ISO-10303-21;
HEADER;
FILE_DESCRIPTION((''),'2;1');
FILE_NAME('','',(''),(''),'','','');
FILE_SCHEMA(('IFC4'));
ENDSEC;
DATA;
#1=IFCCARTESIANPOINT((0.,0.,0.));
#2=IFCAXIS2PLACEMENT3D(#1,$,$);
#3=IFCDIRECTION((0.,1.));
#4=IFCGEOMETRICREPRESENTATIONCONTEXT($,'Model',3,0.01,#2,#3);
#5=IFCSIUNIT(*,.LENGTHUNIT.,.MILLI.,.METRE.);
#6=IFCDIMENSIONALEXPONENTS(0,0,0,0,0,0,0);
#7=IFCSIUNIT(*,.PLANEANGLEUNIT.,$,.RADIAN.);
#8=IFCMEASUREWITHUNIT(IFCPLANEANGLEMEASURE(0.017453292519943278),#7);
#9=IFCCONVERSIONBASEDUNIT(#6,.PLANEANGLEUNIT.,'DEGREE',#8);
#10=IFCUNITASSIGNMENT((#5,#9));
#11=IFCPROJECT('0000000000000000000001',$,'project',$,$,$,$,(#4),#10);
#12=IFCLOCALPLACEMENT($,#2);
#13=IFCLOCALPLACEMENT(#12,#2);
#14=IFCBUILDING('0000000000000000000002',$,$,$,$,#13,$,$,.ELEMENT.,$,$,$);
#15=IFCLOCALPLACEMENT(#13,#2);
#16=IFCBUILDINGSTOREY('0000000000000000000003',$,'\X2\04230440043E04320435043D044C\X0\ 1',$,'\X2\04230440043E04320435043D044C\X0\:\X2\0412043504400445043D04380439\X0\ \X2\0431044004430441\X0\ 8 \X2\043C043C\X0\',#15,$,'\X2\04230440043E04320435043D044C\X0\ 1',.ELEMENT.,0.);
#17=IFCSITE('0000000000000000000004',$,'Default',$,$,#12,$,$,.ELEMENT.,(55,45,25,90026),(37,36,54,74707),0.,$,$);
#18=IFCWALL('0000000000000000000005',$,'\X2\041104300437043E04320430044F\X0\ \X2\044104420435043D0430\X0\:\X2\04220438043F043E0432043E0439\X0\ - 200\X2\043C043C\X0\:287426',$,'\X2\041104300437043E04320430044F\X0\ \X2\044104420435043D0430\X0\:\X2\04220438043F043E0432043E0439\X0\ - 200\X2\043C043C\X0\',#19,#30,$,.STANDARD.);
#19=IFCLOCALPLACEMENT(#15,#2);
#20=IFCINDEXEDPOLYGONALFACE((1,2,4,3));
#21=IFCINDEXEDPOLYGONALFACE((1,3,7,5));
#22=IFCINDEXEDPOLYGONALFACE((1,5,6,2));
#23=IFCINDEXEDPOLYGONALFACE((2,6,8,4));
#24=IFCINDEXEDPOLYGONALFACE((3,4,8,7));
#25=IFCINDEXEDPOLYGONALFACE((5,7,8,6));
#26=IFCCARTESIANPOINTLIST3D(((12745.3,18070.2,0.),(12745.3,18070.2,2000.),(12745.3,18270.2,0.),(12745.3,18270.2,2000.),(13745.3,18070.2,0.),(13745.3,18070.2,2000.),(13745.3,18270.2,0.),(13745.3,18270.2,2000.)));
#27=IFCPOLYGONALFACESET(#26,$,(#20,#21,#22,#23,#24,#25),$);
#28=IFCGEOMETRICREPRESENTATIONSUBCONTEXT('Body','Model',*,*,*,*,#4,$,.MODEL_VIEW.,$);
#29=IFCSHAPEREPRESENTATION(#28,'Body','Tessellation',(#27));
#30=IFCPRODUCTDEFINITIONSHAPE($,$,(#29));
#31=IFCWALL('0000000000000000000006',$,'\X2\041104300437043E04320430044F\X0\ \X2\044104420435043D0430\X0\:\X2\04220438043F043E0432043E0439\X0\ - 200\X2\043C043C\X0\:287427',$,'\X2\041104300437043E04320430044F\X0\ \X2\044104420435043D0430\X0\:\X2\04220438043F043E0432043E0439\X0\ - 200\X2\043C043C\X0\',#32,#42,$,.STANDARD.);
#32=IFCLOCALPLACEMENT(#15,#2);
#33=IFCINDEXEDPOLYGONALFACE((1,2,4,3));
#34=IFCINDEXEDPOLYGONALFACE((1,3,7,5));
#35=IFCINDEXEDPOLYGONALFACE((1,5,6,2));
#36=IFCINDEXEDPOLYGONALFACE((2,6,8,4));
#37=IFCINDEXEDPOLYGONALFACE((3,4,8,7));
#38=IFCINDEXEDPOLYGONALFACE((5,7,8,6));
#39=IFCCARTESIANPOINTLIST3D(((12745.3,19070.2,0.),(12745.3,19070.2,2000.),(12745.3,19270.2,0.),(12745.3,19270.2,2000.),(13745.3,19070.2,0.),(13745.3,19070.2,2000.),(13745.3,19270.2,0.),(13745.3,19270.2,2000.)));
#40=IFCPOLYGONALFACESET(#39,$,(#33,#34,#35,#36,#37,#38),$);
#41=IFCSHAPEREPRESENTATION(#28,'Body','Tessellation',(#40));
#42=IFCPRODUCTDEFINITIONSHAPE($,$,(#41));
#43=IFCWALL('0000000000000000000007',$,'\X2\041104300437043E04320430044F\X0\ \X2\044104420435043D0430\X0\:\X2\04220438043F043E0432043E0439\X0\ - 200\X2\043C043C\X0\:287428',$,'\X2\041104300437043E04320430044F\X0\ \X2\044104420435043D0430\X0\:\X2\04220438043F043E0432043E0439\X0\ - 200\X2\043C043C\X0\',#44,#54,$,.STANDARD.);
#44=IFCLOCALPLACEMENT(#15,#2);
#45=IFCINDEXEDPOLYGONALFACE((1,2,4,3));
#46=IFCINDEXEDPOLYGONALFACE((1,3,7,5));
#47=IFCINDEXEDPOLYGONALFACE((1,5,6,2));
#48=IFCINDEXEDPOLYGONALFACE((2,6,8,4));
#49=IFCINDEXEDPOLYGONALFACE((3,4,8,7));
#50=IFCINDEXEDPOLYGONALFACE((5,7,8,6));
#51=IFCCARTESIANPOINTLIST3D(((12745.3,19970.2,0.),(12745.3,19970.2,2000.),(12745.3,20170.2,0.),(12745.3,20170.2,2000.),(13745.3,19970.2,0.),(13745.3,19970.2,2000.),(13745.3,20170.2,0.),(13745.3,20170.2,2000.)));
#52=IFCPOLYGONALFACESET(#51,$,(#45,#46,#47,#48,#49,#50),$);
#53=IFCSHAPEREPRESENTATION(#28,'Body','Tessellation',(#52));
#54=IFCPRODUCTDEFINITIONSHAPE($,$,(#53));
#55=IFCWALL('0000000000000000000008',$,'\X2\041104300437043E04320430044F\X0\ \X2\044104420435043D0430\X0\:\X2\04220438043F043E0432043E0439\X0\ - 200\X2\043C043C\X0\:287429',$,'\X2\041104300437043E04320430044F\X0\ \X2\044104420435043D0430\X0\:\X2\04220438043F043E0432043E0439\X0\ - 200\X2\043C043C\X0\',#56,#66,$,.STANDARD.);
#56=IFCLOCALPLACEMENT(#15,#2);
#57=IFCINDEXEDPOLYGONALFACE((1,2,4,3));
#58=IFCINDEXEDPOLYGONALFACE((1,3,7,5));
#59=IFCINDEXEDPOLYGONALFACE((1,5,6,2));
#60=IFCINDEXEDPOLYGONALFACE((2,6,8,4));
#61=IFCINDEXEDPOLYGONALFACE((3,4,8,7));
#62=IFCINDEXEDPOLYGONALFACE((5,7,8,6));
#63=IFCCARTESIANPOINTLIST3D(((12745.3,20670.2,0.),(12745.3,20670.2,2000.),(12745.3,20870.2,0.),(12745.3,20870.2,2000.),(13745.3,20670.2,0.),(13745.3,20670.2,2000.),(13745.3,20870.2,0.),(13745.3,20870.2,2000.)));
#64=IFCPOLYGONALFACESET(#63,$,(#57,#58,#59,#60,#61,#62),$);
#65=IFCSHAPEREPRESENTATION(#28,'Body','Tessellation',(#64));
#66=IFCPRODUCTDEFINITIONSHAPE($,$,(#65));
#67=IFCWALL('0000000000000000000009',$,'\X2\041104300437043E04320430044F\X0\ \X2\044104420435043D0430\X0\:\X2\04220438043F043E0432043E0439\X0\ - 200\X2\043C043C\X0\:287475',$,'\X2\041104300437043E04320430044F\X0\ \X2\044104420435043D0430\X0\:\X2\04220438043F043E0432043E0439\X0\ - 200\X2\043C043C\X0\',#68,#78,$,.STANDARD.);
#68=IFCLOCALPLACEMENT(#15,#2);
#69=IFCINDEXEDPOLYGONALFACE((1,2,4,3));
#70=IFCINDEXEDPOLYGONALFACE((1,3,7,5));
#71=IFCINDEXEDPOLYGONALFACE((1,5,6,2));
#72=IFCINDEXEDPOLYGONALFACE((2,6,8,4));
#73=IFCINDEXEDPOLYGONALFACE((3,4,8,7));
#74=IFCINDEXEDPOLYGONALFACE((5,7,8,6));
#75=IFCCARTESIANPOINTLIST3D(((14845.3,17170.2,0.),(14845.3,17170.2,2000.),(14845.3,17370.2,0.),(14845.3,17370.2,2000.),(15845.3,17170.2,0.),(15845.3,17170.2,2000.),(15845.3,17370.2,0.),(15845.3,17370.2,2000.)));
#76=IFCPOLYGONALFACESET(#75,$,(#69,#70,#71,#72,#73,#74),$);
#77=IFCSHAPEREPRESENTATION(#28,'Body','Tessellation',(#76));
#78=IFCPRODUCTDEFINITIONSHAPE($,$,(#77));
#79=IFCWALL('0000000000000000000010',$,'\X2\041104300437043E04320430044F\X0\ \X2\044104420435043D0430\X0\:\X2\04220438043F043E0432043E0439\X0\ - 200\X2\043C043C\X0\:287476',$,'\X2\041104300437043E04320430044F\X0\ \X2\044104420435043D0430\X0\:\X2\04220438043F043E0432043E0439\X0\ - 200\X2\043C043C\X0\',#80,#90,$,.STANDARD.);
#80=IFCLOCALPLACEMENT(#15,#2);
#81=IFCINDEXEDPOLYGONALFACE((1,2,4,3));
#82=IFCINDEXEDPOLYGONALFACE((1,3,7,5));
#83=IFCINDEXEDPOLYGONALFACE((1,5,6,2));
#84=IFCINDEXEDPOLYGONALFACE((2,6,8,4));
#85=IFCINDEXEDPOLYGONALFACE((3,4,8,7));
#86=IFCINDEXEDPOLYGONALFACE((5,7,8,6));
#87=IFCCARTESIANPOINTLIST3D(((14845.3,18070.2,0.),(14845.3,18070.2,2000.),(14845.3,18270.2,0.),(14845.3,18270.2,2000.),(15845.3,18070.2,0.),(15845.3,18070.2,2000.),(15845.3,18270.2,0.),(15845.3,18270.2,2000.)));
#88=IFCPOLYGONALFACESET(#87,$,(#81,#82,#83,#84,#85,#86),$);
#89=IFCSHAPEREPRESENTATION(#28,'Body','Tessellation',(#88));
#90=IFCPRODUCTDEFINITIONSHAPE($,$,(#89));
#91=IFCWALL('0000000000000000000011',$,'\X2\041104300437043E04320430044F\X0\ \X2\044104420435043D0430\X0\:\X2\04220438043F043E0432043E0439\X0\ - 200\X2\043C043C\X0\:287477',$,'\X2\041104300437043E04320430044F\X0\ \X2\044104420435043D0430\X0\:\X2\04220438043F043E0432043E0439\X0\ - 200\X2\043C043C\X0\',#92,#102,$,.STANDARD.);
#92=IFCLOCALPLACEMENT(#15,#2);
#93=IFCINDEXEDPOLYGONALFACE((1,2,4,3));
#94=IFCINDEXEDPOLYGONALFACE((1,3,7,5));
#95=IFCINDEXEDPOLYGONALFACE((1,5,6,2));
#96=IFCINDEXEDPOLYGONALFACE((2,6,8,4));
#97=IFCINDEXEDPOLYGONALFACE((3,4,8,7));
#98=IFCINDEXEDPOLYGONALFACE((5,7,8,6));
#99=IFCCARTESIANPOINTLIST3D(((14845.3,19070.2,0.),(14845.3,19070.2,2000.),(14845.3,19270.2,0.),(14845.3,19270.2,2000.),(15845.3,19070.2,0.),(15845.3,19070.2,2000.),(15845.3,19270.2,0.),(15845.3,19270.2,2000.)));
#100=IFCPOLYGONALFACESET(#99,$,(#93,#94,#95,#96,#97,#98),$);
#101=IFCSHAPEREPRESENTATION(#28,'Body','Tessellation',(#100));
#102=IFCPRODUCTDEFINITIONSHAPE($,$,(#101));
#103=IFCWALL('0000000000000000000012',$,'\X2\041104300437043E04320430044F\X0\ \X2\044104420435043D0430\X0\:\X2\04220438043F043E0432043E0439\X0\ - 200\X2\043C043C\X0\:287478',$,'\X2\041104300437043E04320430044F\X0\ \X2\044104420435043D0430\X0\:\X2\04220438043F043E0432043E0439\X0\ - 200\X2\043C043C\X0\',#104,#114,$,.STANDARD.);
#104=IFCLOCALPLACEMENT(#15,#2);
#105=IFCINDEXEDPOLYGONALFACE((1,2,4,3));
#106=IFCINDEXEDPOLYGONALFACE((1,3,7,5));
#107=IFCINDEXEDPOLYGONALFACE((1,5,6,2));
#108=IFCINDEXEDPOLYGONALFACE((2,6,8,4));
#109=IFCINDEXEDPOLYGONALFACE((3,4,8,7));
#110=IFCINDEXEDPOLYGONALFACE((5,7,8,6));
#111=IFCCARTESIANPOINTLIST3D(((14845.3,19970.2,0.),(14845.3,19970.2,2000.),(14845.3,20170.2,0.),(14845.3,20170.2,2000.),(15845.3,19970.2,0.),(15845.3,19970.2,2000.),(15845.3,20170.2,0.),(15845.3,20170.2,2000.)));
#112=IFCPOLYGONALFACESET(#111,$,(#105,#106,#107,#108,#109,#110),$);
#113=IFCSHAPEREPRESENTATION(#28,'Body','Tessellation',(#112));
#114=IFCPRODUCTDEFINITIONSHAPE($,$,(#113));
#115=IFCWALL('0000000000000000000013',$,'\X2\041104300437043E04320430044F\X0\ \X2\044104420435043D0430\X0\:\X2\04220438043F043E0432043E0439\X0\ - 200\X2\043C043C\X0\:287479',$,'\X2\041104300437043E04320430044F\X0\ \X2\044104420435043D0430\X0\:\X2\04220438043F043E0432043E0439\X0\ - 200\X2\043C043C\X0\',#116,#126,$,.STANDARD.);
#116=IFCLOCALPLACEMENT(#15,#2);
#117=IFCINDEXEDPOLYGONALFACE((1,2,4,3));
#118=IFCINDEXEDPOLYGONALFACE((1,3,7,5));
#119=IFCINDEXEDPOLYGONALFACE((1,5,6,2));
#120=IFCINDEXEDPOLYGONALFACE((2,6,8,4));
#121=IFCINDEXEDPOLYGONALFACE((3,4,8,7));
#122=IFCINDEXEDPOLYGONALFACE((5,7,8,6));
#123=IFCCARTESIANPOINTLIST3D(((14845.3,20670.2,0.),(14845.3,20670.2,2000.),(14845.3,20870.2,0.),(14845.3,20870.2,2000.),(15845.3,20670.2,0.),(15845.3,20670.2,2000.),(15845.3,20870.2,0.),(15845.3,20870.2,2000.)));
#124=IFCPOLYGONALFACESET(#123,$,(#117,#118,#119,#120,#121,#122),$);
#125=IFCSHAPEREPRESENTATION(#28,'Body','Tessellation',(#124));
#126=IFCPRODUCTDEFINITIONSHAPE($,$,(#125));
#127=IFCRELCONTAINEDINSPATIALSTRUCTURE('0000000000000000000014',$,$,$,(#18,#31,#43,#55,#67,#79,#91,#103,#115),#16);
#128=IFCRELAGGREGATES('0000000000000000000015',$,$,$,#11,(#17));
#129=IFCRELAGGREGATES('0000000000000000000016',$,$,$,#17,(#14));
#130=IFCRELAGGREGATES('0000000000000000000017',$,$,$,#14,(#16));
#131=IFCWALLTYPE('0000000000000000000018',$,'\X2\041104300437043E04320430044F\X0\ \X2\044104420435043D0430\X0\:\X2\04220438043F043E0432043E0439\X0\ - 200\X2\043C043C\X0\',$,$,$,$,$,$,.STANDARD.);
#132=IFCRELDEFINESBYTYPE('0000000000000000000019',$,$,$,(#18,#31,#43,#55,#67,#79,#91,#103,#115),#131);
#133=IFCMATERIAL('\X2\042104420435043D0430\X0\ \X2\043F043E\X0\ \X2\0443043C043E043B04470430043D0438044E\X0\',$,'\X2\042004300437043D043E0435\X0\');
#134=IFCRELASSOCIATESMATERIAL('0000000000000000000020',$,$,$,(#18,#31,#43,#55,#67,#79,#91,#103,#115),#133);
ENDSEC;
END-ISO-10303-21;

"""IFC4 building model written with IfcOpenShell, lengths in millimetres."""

from ifc_helpers import new_model, entity, si_unit, converted_unit, direction, frame, origin, place, context, subcontext, project, spatial, indexed_curve, outline, extrude, material, type_object, element, save


model = new_model("IFC4")

# Units and contexts
model_context = context("Model", 3, precision=0.01, world=origin(), true_north=direction((0.0, 1.0)))
body_context = subcontext(model_context, "Body", "Model", "MODEL_VIEW")
ifc_project = project(units=[si_unit("LENGTHUNIT", "METRE", prefix="MILLI"), converted_unit("PLANEANGLEUNIT", "DEGREE", entity("IfcPlaneAngleMeasure", 0.017453292519943278), si_unit("PLANEANGLEUNIT", "RADIAN"), dimensions=[0, 0, 0, 0, 0, 0, 0])], contexts=[model_context])

# Site, building, storey
site_placement = place(None, origin())
site = spatial("IfcSite", under=ifc_project, at=site_placement, Name="Default", CompositionType="ELEMENT", RefLatitude=(55, 45, 25, 90026), RefLongitude=(37, 36, 54, 74707), RefElevation=0.0)
building_placement = place(site_placement, origin())
building = spatial("IfcBuilding", under=site, at=building_placement, CompositionType="ELEMENT")
storey_placement = place(building_placement, origin())
storey = spatial("IfcBuildingStorey", under=building, at=storey_placement, Name="Уровень 1", ObjectType="Уровень:Верхний брус 8 мм", LongName="Уровень 1", CompositionType="ELEMENT", Elevation=0.0)

# Walls
ifc_material = material(Name="Стена по умолчанию", Category="Разное")
wall_type = type_object("IfcWallType", Name="Базовая стена:Типовой - 200мм", PredefinedType="STANDARD")
for number, where, name in (
    (1, (12745.3, 18170.2, 0.0), "Базовая стена:Типовой - 200мм:287426"),
    (2, (12745.3, 19170.2, 0.0), "Базовая стена:Типовой - 200мм:287427"),
):
    element("IfcWall", number, at=place(storey_placement, frame(where)), inside=storey, type_object=wall_type, material=ifc_material, Name=name, ObjectType="Базовая стена:Типовой - 200мм", PredefinedType="STANDARD", context=body_context, shape_type="SweptSolid", body=[
        extrude(outline(indexed_curve([(1000.0, 100.0), (0.0, 100.0), (0.0, -100.0), (1000.0, -100.0), (1000.0, 100.0)], self_intersect=False)), origin(), (0.0, 0.0, 1.0), 2000.0),
    ])
wall_1_placement = place(storey_placement, frame((12745.3, 20070.2, 0.0)))
element("IfcWall", 3, at=wall_1_placement, inside=storey, type_object=wall_type, material=ifc_material, Name="Базовая стена:Типовой - 200мм:287428", ObjectType="Базовая стена:Типовой - 200мм", PredefinedType="STANDARD", context=body_context, shape_type="SweptSolid", body=[
    extrude(outline(indexed_curve([(1000.0, 100.0), (0.0, 100.0), (0.0, -100.0), (1000.0, -100.0), (1000.0, 100.0)], self_intersect=False)), origin(), (0.0, 0.0, 1.0), 2000.0),
])
wall_2_placement = place(storey_placement, frame((12745.3, 20770.2, 0.0)))
element("IfcWall", 4, at=wall_2_placement, inside=storey, type_object=wall_type, material=ifc_material, Name="Базовая стена:Типовой - 200мм:287429", ObjectType="Базовая стена:Типовой - 200мм", PredefinedType="STANDARD", context=body_context, shape_type="SweptSolid", body=[
    extrude(outline(indexed_curve([(1000.0, 100.0), (0.0, 100.0), (0.0, -100.0), (1000.0, -100.0), (1000.0, 100.0)], self_intersect=False)), origin(), (0.0, 0.0, 1.0), 2000.0),
])
wall_3_placement = place(storey_placement, frame((14845.3, 17270.2, 0.0)))
element("IfcWall", 5, at=wall_3_placement, inside=storey, type_object=wall_type, material=ifc_material, Name="Базовая стена:Типовой - 200мм:287475", ObjectType="Базовая стена:Типовой - 200мм", PredefinedType="STANDARD", context=body_context, shape_type="SweptSolid", body=[
    extrude(outline(indexed_curve([(1000.0, 100.0), (0.0, 100.0), (0.0, -100.0), (1000.0, -100.0), (1000.0, 100.0)], self_intersect=False)), origin(), (0.0, 0.0, 1.0), 2000.0),
])
wall_4_placement = place(storey_placement, frame((14845.3, 18170.2, 0.0)))
element("IfcWall", 6, at=wall_4_placement, inside=storey, type_object=wall_type, material=ifc_material, Name="Базовая стена:Типовой - 200мм:287476", ObjectType="Базовая стена:Типовой - 200мм", PredefinedType="STANDARD", context=body_context, shape_type="SweptSolid", body=[
    extrude(outline(indexed_curve([(1000.0, 100.0), (0.0, 100.0), (0.0, -100.0), (1000.0, -100.0), (1000.0, 100.0)], self_intersect=False)), origin(), (0.0, 0.0, 1.0), 2000.0),
])
wall_5_placement = place(storey_placement, frame((14845.3, 19170.2, 0.0)))
element("IfcWall", 7, at=wall_5_placement, inside=storey, type_object=wall_type, material=ifc_material, Name="Базовая стена:Типовой - 200мм:287477", ObjectType="Базовая стена:Типовой - 200мм", PredefinedType="STANDARD", context=body_context, shape_type="SweptSolid", body=[
    extrude(outline(indexed_curve([(1000.0, 100.0), (0.0, 100.0), (0.0, -100.0), (1000.0, -100.0), (1000.0, 100.0)], self_intersect=False)), origin(), (0.0, 0.0, 1.0), 2000.0),
])
wall_6_placement = place(storey_placement, frame((14845.3, 20070.2, 0.0)))
element("IfcWall", 8, at=wall_6_placement, inside=storey, type_object=wall_type, material=ifc_material, Name="Базовая стена:Типовой - 200мм:287478", ObjectType="Базовая стена:Типовой - 200мм", PredefinedType="STANDARD", context=body_context, shape_type="SweptSolid", body=[
    extrude(outline(indexed_curve([(1000.0, 100.0), (0.0, 100.0), (0.0, -100.0), (1000.0, -100.0), (1000.0, 100.0)], self_intersect=False)), origin(), (0.0, 0.0, 1.0), 2000.0),
])
wall_7_placement = place(storey_placement, frame((14845.3, 20770.2, 0.0)))
element("IfcWall", 9, at=wall_7_placement, inside=storey, type_object=wall_type, material=ifc_material, Name="Базовая стена:Типовой - 200мм:287479", ObjectType="Базовая стена:Типовой - 200мм", PredefinedType="STANDARD", context=body_context, shape_type="SweptSolid", body=[
    extrude(outline(indexed_curve([(1000.0, 100.0), (0.0, 100.0), (0.0, -100.0), (1000.0, -100.0), (1000.0, 100.0)], self_intersect=False)), origin(), (0.0, 0.0, 1.0), 2000.0),
])

save(model, "model.ifc")
